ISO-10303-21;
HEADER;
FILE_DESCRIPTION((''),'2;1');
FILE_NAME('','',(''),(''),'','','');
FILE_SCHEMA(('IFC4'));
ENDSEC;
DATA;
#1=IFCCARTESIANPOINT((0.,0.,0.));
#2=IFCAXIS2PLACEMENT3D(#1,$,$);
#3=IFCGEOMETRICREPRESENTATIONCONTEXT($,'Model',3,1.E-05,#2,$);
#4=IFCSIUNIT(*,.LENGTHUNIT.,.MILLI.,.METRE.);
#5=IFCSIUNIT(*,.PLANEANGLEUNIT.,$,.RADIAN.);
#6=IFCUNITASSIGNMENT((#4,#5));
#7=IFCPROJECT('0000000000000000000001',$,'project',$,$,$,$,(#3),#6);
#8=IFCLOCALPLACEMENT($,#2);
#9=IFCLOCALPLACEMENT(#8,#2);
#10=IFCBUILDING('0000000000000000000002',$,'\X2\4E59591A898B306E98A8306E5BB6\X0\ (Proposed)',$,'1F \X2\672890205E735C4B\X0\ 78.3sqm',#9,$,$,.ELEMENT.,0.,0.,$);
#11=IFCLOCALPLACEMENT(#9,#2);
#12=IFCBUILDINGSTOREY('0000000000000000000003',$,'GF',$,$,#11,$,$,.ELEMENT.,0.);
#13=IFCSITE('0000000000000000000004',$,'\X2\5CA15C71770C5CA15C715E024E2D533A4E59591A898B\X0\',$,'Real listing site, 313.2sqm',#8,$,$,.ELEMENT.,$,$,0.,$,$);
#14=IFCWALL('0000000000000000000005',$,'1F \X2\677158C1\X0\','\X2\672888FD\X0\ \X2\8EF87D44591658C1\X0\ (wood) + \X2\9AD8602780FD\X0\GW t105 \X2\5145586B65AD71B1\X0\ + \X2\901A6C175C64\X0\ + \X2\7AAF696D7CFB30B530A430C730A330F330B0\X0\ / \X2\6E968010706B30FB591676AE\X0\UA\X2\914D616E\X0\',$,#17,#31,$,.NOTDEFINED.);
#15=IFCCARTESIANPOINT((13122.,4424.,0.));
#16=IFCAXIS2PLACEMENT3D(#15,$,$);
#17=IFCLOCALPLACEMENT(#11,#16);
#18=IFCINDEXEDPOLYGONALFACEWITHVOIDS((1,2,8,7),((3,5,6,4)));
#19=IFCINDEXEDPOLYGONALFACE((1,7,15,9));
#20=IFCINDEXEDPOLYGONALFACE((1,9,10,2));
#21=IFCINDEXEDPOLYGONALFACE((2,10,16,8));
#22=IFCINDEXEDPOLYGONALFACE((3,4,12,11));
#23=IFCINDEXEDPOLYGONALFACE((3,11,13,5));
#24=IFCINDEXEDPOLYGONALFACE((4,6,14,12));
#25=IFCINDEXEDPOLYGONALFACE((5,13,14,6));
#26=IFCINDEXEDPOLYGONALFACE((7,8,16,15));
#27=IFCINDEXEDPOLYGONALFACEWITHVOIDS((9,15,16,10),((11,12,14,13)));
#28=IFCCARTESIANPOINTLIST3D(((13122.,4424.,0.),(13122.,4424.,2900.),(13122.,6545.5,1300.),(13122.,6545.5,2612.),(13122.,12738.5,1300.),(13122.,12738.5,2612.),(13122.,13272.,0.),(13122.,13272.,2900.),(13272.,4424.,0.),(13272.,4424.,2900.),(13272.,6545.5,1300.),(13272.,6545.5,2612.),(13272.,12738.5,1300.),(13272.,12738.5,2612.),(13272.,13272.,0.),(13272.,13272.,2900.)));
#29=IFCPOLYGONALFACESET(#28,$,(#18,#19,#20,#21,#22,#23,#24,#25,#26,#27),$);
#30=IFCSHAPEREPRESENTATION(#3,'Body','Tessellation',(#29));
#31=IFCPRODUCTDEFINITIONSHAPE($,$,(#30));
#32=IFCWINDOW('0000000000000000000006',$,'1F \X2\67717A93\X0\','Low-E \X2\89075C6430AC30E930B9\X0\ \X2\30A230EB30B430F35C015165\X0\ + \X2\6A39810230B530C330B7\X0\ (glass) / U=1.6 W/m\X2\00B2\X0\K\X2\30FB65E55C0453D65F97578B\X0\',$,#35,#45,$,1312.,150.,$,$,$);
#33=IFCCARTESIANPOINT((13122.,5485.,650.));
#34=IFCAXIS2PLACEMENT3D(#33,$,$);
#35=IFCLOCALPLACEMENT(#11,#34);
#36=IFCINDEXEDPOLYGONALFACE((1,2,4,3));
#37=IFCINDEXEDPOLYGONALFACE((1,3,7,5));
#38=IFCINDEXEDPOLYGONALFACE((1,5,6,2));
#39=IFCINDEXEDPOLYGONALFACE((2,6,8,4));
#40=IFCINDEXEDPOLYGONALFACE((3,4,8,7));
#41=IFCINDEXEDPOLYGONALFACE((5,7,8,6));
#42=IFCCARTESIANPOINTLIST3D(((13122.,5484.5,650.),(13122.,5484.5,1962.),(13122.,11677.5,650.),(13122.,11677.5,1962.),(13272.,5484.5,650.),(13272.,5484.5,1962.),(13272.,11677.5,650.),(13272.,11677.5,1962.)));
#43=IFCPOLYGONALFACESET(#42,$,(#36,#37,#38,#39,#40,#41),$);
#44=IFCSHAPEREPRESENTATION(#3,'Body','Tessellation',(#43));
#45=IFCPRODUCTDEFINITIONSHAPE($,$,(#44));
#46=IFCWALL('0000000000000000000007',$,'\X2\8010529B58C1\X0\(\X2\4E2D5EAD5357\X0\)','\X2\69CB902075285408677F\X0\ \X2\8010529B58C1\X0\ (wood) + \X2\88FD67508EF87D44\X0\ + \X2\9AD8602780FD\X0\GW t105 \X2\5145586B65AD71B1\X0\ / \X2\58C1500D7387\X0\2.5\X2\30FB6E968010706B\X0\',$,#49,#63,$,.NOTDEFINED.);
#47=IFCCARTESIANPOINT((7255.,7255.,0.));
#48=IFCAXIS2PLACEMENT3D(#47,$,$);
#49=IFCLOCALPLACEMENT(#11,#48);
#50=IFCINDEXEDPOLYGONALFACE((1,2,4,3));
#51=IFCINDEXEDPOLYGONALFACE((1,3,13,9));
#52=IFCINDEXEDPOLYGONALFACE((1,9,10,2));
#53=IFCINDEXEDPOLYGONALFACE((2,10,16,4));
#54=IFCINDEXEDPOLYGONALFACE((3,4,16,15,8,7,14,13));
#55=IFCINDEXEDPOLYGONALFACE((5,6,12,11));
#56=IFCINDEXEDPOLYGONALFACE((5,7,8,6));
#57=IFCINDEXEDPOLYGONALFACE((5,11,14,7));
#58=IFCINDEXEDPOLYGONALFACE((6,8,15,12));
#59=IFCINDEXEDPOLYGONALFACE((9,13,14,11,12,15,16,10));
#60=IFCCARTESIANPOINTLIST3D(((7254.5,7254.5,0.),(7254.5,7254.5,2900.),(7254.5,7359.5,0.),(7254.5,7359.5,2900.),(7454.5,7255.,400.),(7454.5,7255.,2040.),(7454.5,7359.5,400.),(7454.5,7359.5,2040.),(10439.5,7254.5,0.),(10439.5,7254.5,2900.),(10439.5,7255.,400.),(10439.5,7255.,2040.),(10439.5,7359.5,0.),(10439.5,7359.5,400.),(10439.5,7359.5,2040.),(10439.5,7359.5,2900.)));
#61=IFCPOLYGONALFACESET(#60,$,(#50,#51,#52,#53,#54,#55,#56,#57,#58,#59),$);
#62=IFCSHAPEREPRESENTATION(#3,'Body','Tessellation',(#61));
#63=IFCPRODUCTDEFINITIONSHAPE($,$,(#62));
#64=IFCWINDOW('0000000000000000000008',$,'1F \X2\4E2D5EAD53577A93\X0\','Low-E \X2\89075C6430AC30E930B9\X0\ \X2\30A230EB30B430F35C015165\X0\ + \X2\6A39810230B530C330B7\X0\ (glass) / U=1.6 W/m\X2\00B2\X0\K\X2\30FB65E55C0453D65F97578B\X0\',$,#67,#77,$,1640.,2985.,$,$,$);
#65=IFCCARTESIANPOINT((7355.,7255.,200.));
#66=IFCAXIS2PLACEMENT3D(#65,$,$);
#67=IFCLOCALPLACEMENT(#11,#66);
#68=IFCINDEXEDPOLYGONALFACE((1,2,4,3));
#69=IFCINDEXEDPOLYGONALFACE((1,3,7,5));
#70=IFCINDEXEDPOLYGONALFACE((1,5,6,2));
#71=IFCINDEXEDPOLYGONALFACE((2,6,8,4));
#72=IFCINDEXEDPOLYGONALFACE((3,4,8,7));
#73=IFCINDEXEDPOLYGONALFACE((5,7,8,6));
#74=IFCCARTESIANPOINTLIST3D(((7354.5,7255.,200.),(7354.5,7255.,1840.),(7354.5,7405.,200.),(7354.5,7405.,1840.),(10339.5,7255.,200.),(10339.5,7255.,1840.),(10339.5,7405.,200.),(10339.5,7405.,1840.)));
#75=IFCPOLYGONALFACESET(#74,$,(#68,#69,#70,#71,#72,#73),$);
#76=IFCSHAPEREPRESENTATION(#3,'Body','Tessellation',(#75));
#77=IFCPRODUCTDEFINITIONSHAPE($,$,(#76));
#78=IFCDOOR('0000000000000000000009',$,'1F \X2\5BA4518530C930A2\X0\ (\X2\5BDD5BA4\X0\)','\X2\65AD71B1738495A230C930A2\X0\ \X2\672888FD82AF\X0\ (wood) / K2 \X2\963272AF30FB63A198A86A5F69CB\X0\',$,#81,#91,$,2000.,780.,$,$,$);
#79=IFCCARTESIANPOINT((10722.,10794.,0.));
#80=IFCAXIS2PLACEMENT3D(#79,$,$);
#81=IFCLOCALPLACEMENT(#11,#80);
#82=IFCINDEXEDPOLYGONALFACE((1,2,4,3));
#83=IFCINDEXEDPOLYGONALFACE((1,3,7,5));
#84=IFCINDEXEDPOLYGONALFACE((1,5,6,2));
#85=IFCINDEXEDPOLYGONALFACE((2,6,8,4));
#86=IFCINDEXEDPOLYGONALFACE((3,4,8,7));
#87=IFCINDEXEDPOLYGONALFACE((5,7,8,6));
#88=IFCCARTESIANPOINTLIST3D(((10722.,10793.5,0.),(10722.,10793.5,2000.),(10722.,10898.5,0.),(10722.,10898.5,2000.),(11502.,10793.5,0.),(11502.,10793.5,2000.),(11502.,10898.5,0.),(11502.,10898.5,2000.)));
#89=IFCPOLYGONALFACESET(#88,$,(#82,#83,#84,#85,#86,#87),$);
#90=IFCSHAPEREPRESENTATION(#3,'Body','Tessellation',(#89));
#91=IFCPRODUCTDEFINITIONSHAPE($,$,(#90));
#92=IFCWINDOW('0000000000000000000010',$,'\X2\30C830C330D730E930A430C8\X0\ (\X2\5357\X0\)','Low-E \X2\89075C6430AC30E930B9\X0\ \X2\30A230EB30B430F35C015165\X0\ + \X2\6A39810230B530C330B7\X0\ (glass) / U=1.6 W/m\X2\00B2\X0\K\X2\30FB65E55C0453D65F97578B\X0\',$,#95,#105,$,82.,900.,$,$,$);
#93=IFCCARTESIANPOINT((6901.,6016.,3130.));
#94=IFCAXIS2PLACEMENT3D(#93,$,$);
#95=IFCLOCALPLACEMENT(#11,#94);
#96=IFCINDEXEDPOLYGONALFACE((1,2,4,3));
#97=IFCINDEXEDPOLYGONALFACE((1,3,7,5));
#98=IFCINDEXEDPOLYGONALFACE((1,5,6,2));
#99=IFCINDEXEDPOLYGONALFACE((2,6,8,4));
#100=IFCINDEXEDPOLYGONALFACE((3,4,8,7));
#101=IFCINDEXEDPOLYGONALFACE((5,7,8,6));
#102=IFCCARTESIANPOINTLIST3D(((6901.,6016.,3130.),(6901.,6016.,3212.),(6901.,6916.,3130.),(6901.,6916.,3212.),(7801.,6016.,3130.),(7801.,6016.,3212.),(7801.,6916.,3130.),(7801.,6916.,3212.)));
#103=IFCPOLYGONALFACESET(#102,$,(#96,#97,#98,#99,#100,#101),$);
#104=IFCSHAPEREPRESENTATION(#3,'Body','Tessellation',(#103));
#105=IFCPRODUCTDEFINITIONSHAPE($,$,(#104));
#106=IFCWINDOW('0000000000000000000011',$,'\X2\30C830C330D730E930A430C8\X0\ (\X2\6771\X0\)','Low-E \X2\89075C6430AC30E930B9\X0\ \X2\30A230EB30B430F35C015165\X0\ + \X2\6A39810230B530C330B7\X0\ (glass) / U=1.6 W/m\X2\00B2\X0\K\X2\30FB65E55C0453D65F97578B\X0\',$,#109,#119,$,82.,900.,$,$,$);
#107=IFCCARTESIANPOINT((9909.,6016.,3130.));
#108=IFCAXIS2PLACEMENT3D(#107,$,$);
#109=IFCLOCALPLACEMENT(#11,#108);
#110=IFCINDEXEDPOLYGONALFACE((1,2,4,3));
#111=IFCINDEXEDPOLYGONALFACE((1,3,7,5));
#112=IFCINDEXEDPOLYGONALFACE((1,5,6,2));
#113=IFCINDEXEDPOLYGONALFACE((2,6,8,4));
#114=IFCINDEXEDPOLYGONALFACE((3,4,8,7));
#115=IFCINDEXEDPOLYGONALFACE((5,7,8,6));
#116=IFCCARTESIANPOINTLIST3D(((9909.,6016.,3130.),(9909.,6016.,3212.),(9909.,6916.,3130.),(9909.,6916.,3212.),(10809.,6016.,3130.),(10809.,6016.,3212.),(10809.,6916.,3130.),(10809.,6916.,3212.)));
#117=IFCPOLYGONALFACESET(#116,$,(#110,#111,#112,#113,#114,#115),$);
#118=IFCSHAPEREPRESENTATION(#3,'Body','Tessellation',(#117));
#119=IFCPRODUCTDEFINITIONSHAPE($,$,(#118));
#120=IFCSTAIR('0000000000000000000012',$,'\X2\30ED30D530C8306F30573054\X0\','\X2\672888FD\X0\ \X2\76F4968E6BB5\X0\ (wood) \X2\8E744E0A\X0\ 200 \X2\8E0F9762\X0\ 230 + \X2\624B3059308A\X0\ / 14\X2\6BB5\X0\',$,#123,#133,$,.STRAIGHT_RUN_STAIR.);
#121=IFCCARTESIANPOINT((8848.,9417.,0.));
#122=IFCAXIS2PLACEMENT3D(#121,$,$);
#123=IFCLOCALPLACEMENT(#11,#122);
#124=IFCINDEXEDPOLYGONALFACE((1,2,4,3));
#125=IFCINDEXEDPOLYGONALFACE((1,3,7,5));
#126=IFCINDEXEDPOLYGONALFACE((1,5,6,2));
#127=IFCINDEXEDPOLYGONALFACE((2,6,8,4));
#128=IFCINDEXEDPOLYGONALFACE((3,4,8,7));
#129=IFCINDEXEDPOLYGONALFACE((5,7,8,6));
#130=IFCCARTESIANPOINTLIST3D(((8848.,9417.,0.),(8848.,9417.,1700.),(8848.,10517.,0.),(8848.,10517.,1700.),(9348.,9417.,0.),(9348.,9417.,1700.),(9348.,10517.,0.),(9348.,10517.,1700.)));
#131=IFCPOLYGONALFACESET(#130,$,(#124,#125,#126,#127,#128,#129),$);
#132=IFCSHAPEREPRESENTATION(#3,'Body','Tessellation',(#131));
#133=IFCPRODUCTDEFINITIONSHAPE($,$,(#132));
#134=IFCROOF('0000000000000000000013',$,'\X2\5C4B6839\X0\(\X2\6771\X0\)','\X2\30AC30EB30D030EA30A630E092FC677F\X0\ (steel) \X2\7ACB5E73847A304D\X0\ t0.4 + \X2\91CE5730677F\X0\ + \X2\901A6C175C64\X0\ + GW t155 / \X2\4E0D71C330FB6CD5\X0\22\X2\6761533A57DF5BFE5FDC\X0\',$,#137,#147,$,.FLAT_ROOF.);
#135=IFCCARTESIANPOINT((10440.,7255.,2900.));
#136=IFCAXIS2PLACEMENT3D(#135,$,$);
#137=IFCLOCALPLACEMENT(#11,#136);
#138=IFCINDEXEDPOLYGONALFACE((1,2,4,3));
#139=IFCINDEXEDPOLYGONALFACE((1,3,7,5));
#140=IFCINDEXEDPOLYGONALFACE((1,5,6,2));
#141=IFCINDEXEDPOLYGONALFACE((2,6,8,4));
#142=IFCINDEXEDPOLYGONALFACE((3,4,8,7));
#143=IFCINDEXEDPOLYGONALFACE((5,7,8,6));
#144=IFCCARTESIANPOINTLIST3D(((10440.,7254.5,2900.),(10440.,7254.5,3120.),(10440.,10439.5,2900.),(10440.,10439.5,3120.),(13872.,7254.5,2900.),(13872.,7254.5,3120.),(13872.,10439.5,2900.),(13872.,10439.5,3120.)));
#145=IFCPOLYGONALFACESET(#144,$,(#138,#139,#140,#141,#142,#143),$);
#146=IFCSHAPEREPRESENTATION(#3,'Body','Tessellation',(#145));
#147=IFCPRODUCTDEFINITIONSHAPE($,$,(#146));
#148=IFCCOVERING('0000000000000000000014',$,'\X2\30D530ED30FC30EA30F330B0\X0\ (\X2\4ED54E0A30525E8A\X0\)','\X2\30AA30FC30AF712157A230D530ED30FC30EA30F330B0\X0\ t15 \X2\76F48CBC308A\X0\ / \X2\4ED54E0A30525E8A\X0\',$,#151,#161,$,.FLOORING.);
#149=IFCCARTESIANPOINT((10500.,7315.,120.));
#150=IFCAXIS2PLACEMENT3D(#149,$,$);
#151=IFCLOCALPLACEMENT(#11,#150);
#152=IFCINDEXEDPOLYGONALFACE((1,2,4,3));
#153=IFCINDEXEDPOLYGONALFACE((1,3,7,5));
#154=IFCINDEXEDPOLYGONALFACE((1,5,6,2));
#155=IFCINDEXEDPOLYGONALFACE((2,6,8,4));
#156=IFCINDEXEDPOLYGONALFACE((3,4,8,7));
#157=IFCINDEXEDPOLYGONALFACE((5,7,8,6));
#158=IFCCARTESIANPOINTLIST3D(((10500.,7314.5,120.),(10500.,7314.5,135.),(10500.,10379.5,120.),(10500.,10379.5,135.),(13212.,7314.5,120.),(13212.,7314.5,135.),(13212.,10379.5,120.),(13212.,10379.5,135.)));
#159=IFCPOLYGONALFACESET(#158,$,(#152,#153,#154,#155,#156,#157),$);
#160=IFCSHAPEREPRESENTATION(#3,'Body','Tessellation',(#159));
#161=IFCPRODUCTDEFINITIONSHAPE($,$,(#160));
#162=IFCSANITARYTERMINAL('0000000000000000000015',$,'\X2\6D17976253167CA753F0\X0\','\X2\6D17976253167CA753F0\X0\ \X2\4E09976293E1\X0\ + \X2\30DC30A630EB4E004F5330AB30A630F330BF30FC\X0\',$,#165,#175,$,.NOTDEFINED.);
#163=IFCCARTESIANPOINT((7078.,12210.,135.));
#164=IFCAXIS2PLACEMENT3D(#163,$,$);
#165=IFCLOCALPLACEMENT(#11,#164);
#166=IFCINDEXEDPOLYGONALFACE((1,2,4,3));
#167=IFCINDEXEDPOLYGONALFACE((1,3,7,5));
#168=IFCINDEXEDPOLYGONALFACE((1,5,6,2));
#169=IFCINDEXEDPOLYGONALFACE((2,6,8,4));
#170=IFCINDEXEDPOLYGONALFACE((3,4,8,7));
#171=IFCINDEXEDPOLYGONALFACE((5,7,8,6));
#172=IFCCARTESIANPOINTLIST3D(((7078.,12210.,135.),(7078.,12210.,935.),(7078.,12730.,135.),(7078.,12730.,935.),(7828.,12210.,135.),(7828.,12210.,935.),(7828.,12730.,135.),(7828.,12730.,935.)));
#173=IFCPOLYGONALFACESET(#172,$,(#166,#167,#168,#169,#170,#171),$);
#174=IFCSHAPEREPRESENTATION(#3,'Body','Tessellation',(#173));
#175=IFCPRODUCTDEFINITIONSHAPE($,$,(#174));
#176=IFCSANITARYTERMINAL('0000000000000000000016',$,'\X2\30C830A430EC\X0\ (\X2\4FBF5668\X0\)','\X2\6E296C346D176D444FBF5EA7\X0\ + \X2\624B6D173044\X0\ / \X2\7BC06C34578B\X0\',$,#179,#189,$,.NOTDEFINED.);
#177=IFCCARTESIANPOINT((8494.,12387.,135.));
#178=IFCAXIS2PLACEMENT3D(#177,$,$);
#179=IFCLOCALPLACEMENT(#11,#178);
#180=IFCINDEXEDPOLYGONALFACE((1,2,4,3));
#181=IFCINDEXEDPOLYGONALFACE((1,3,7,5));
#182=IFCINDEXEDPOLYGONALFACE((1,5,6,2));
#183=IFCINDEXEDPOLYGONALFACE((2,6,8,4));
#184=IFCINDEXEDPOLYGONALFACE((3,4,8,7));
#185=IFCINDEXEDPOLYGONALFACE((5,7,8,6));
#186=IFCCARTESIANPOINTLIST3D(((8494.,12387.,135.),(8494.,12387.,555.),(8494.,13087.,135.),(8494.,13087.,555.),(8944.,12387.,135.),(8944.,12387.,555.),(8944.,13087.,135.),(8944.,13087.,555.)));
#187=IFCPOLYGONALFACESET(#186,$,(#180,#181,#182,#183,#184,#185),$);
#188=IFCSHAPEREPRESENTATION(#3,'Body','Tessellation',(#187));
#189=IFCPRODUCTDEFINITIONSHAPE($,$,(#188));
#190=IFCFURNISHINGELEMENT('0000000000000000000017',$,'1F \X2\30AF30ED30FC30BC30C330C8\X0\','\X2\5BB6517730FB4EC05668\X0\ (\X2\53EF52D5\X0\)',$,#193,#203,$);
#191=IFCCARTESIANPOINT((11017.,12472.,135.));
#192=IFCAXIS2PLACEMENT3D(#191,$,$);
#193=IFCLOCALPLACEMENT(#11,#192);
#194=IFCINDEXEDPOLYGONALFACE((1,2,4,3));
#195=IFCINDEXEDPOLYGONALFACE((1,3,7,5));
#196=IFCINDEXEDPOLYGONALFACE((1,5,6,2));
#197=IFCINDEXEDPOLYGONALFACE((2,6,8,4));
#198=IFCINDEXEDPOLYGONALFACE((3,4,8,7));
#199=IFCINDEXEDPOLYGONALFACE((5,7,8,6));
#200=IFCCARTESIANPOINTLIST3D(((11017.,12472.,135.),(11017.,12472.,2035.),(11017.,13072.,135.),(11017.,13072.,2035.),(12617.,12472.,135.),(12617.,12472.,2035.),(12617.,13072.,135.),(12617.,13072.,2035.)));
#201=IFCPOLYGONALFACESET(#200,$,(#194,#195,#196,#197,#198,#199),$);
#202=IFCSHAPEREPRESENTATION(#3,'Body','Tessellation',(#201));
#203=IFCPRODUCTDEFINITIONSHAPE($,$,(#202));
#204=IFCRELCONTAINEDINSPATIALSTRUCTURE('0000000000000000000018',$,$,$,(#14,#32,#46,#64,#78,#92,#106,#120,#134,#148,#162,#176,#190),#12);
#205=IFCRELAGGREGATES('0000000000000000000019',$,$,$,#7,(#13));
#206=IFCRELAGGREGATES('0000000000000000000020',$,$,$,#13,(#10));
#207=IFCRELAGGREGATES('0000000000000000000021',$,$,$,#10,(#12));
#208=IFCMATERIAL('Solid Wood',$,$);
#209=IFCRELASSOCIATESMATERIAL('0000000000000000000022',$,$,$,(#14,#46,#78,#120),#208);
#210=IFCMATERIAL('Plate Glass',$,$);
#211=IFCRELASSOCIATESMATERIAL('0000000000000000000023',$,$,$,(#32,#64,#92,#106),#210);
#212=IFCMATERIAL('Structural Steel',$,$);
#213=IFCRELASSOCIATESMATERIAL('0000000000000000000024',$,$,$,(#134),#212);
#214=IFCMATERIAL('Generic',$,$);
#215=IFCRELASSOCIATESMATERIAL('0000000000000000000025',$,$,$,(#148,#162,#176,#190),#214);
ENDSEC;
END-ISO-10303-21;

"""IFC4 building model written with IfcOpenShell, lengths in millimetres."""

from ifc_helpers import new_model, si_unit, frame, frame_2d, origin, place, context, project, spatial, rectangle, extrude, material, element, fill, save


model = new_model("IFC4")

# Units and contexts
model_context = context("Model", 3, precision=1e-05, world=origin())
ifc_project = project(units=[si_unit("LENGTHUNIT", "METRE", prefix="MILLI"), si_unit("PLANEANGLEUNIT", "RADIAN")], contexts=[model_context])

# Site, building, storey
site_placement = place(None, origin())
site = spatial("IfcSite", under=ifc_project, at=site_placement, Name="岡山県岡山市中区乙多見", ObjectType="Real listing site, 313.2sqm", CompositionType="ELEMENT", RefElevation=0.0)
building_placement = place(site_placement, origin())
building = spatial("IfcBuilding", under=site, at=building_placement, Name="乙多見の風の家 (Proposed)", ObjectType="1F 木造平屋 78.3sqm", CompositionType="ELEMENT", ElevationOfRefHeight=0.0, ElevationOfTerrain=0.0)
storey_placement = place(building_placement, origin())
storey = spatial("IfcBuildingStorey", under=building, at=storey_placement, Name="GF", CompositionType="ELEMENT", Elevation=0.0)

# Shared definitions
ifc_material_1 = material(Name="Solid Wood")

# Walls, openings, windows
wall_1_placement = place(storey_placement, frame((13122.0, 4424.0, 0.0)))
wall_1 = element("IfcWall", 1, at=wall_1_placement, inside=storey, material=ifc_material_1, Name="1F 東壁", Description="木製 軸組外壁 (wood) + 高性能GW t105 充填断熱 + 通気層 + 窯業系サイディング / 準耐火・外皮UA配慮", PredefinedType="NOTDEFINED", context=model_context, shape_type="SweptSolid", body=[
    extrude(rectangle(XDim=150.0, YDim=8848.0, at=frame_2d((75.0, 4424.0))), frame((13122.0, 4424.0, 0.0)), (0.0, 0.0, 1.0), 2900.0),
])
opening_1_placement = place(storey_placement, frame((13122.0, 5485.0, 650.0)))
opening_1 = element("IfcOpeningElement", 2, at=opening_1_placement, cuts=wall_1, PredefinedType="NOTDEFINED", context=model_context, shape_type="SweptSolid", body=[
    extrude(rectangle(XDim=150.0, YDim=6193.0, at=frame_2d((75.0, 3096.0))), frame((13122.0, 5485.0, 650.0)), (0.0, 0.0, 1.0), 1312.0),
])
ifc_material_2 = material(Name="Plate Glass")
window_1_placement = place(storey_placement, frame((13122.0, 5485.0, 650.0)))
window_1 = element("IfcWindow", 3, at=window_1_placement, inside=storey, material=ifc_material_2, Name="1F 東窓", Description="Low-E 複層ガラス アルゴン封入 + 樹脂サッシ (glass) / U=1.6 W/m²K・日射取得型", OverallHeight=1312.0, OverallWidth=150.0, context=model_context, shape_type="SweptSolid", body=[
    extrude(rectangle(XDim=150.0, YDim=6193.0, at=frame_2d((75.0, 3096.0))), frame((13122.0, 5485.0, 650.0)), (0.0, 0.0, 1.0), 1312.0),
])
fill(opening_1, window_1)
wall_2_placement = place(storey_placement, frame((7255.0, 7255.0, 0.0)))
wall_2 = element("IfcWall", 4, at=wall_2_placement, inside=storey, material=ifc_material_1, Name="耐力壁(中庭南)", Description="構造用合板 耐力壁 (wood) + 製材軸組 + 高性能GW t105 充填断熱 / 壁倍率2.5・準耐火", PredefinedType="NOTDEFINED", context=model_context, shape_type="SweptSolid", body=[
    extrude(rectangle(XDim=3185.0, YDim=105.0, at=frame_2d((1592.0, 52.0))), frame((7255.0, 7255.0, 0.0)), (0.0, 0.0, 1.0), 2900.0),
])
opening_2_placement = place(storey_placement, frame((7355.0, 7255.0, 200.0)))
opening_2 = element("IfcOpeningElement", 5, at=opening_2_placement, cuts=wall_2, PredefinedType="NOTDEFINED", context=model_context, shape_type="SweptSolid", body=[
    extrude(rectangle(XDim=2985.0, YDim=150.0, at=frame_2d((1492.0, 75.0))), frame((7355.0, 7255.0, 200.0)), (0.0, 0.0, 1.0), 1640.0),
])
window_2_placement = place(storey_placement, frame((7355.0, 7255.0, 200.0)))
window_2 = element("IfcWindow", 6, at=window_2_placement, inside=storey, material=ifc_material_2, Name="1F 中庭南窓", Description="Low-E 複層ガラス アルゴン封入 + 樹脂サッシ (glass) / U=1.6 W/m²K・日射取得型", OverallHeight=1640.0, OverallWidth=2985.0, context=model_context, shape_type="SweptSolid", body=[
    extrude(rectangle(XDim=2985.0, YDim=150.0, at=frame_2d((1492.0, 75.0))), frame((7355.0, 7255.0, 200.0)), (0.0, 0.0, 1.0), 1640.0),
])
fill(opening_2, window_2)

# Door
door_placement = place(storey_placement, frame((10722.0, 10794.0, 0.0)))
element("IfcDoor", 7, at=door_placement, inside=storey, material=ifc_material_1, Name="1F 室内ドア (寝室)", Description="断熱玄関ドア 木製芯 (wood) / K2 防犯・採風機構", OverallHeight=2000.0, OverallWidth=780.0, context=model_context, shape_type="SweptSolid", body=[
    extrude(rectangle(XDim=780.0, YDim=105.0, at=frame_2d((390.0, 52.0))), frame((10722.0, 10794.0, 0.0)), (0.0, 0.0, 1.0), 2000.0),
])

# Windows
window_3_placement = place(storey_placement, frame((6901.0, 6016.0, 3130.0)))
element("IfcWindow", 8, at=window_3_placement, inside=storey, material=ifc_material_2, Name="トップライト (南)", Description="Low-E 複層ガラス アルゴン封入 + 樹脂サッシ (glass) / U=1.6 W/m²K・日射取得型", OverallHeight=82.0, OverallWidth=900.0, context=model_context, shape_type="SweptSolid", body=[
    extrude(rectangle(XDim=900.0, YDim=900.0, at=frame_2d((450.0, 450.0))), frame((6901.0, 6016.0, 3130.0)), (0.0, 0.0, 1.0), 82.0),
])
window_4_placement = place(storey_placement, frame((9909.0, 6016.0, 3130.0)))
element("IfcWindow", 9, at=window_4_placement, inside=storey, material=ifc_material_2, Name="トップライト (東)", Description="Low-E 複層ガラス アルゴン封入 + 樹脂サッシ (glass) / U=1.6 W/m²K・日射取得型", OverallHeight=82.0, OverallWidth=900.0, context=model_context, shape_type="SweptSolid", body=[
    extrude(rectangle(XDim=900.0, YDim=900.0, at=frame_2d((450.0, 450.0))), frame((9909.0, 6016.0, 3130.0)), (0.0, 0.0, 1.0), 82.0),
])

# Stair
stair_placement = place(storey_placement, frame((8848.0, 9417.0, 0.0)))
element("IfcStair", 10, at=stair_placement, inside=storey, material=ifc_material_1, Name="ロフトはしご", Description="木製 直階段 (wood) 蹴上 200 踏面 230 + 手すり / 14段", PredefinedType="STRAIGHT_RUN_STAIR", context=model_context, shape_type="SweptSolid", body=[
    extrude(rectangle(XDim=500.0, YDim=1100.0, at=frame_2d((250.0, 550.0))), frame((8848.0, 9417.0, 0.0)), (0.0, 0.0, 1.0), 1700.0),
])

# Roof
ifc_material_3 = material(Name="Structural Steel")
roof_placement = place(storey_placement, frame((10440.0, 7255.0, 2900.0)))
element("IfcRoof", 11, at=roof_placement, inside=storey, material=ifc_material_3, Name="屋根(東)", Description="ガルバリウム鋼板 (steel) 立平葺き t0.4 + 野地板 + 通気層 + GW t155 / 不燃・法22条区域対応", PredefinedType="FLAT_ROOF", context=model_context, shape_type="SweptSolid", body=[
    extrude(rectangle(XDim=3432.0, YDim=3185.0, at=frame_2d((1716.0, 1592.0))), frame((10440.0, 7255.0, 2900.0)), (0.0, 0.0, 1.0), 220.0),
])

# Covering
ifc_material_4 = material(Name="Generic")
covering_placement = place(storey_placement, frame((10500.0, 7315.0, 120.0)))
element("IfcCovering", 12, at=covering_placement, inside=storey, material=ifc_material_4, Name="フローリング (仕上げ床)", Description="オーク無垢フローリング t15 直貼り / 仕上げ床", PredefinedType="FLOORING", context=model_context, shape_type="SweptSolid", body=[
    extrude(rectangle(XDim=2712.0, YDim=3065.0, at=frame_2d((1356.0, 1532.0))), frame((10500.0, 7315.0, 120.0)), (0.0, 0.0, 1.0), 15.0),
])

# Sanitary terminals
sanitary_terminal_1_placement = place(storey_placement, frame((7078.0, 12210.0, 135.0)))
element("IfcSanitaryTerminal", 13, at=sanitary_terminal_1_placement, inside=storey, material=ifc_material_4, Name="洗面化粧台", Description="洗面化粧台 三面鏡 + ボウル一体カウンター", PredefinedType="NOTDEFINED", context=model_context, shape_type="SweptSolid", body=[
    extrude(rectangle(XDim=750.0, YDim=520.0, at=frame_2d((375.0, 260.0))), frame((7078.0, 12210.0, 135.0)), (0.0, 0.0, 1.0), 800.0),
])
sanitary_terminal_2_placement = place(storey_placement, frame((8494.0, 12387.0, 135.0)))
element("IfcSanitaryTerminal", 14, at=sanitary_terminal_2_placement, inside=storey, material=ifc_material_4, Name="トイレ (便器)", Description="温水洗浄便座 + 手洗い / 節水型", PredefinedType="NOTDEFINED", context=model_context, shape_type="SweptSolid", body=[
    extrude(rectangle(XDim=450.0, YDim=700.0, at=frame_2d((225.0, 350.0))), frame((8494.0, 12387.0, 135.0)), (0.0, 0.0, 1.0), 420.0),
])

# Furnishing element
furnishing_1_placement = place(storey_placement, frame((11017.0, 12472.0, 135.0)))
element("IfcFurnishingElement", 15, at=furnishing_1_placement, inside=storey, material=ifc_material_4, Name="1F クローゼット", Description="家具・什器 (可動)", context=model_context, shape_type="SweptSolid", body=[
    extrude(rectangle(XDim=1600.0, YDim=600.0, at=frame_2d((800.0, 300.0))), frame((11017.0, 12472.0, 135.0)), (0.0, 0.0, 1.0), 1900.0),
])

save(model, "model.ifc")
